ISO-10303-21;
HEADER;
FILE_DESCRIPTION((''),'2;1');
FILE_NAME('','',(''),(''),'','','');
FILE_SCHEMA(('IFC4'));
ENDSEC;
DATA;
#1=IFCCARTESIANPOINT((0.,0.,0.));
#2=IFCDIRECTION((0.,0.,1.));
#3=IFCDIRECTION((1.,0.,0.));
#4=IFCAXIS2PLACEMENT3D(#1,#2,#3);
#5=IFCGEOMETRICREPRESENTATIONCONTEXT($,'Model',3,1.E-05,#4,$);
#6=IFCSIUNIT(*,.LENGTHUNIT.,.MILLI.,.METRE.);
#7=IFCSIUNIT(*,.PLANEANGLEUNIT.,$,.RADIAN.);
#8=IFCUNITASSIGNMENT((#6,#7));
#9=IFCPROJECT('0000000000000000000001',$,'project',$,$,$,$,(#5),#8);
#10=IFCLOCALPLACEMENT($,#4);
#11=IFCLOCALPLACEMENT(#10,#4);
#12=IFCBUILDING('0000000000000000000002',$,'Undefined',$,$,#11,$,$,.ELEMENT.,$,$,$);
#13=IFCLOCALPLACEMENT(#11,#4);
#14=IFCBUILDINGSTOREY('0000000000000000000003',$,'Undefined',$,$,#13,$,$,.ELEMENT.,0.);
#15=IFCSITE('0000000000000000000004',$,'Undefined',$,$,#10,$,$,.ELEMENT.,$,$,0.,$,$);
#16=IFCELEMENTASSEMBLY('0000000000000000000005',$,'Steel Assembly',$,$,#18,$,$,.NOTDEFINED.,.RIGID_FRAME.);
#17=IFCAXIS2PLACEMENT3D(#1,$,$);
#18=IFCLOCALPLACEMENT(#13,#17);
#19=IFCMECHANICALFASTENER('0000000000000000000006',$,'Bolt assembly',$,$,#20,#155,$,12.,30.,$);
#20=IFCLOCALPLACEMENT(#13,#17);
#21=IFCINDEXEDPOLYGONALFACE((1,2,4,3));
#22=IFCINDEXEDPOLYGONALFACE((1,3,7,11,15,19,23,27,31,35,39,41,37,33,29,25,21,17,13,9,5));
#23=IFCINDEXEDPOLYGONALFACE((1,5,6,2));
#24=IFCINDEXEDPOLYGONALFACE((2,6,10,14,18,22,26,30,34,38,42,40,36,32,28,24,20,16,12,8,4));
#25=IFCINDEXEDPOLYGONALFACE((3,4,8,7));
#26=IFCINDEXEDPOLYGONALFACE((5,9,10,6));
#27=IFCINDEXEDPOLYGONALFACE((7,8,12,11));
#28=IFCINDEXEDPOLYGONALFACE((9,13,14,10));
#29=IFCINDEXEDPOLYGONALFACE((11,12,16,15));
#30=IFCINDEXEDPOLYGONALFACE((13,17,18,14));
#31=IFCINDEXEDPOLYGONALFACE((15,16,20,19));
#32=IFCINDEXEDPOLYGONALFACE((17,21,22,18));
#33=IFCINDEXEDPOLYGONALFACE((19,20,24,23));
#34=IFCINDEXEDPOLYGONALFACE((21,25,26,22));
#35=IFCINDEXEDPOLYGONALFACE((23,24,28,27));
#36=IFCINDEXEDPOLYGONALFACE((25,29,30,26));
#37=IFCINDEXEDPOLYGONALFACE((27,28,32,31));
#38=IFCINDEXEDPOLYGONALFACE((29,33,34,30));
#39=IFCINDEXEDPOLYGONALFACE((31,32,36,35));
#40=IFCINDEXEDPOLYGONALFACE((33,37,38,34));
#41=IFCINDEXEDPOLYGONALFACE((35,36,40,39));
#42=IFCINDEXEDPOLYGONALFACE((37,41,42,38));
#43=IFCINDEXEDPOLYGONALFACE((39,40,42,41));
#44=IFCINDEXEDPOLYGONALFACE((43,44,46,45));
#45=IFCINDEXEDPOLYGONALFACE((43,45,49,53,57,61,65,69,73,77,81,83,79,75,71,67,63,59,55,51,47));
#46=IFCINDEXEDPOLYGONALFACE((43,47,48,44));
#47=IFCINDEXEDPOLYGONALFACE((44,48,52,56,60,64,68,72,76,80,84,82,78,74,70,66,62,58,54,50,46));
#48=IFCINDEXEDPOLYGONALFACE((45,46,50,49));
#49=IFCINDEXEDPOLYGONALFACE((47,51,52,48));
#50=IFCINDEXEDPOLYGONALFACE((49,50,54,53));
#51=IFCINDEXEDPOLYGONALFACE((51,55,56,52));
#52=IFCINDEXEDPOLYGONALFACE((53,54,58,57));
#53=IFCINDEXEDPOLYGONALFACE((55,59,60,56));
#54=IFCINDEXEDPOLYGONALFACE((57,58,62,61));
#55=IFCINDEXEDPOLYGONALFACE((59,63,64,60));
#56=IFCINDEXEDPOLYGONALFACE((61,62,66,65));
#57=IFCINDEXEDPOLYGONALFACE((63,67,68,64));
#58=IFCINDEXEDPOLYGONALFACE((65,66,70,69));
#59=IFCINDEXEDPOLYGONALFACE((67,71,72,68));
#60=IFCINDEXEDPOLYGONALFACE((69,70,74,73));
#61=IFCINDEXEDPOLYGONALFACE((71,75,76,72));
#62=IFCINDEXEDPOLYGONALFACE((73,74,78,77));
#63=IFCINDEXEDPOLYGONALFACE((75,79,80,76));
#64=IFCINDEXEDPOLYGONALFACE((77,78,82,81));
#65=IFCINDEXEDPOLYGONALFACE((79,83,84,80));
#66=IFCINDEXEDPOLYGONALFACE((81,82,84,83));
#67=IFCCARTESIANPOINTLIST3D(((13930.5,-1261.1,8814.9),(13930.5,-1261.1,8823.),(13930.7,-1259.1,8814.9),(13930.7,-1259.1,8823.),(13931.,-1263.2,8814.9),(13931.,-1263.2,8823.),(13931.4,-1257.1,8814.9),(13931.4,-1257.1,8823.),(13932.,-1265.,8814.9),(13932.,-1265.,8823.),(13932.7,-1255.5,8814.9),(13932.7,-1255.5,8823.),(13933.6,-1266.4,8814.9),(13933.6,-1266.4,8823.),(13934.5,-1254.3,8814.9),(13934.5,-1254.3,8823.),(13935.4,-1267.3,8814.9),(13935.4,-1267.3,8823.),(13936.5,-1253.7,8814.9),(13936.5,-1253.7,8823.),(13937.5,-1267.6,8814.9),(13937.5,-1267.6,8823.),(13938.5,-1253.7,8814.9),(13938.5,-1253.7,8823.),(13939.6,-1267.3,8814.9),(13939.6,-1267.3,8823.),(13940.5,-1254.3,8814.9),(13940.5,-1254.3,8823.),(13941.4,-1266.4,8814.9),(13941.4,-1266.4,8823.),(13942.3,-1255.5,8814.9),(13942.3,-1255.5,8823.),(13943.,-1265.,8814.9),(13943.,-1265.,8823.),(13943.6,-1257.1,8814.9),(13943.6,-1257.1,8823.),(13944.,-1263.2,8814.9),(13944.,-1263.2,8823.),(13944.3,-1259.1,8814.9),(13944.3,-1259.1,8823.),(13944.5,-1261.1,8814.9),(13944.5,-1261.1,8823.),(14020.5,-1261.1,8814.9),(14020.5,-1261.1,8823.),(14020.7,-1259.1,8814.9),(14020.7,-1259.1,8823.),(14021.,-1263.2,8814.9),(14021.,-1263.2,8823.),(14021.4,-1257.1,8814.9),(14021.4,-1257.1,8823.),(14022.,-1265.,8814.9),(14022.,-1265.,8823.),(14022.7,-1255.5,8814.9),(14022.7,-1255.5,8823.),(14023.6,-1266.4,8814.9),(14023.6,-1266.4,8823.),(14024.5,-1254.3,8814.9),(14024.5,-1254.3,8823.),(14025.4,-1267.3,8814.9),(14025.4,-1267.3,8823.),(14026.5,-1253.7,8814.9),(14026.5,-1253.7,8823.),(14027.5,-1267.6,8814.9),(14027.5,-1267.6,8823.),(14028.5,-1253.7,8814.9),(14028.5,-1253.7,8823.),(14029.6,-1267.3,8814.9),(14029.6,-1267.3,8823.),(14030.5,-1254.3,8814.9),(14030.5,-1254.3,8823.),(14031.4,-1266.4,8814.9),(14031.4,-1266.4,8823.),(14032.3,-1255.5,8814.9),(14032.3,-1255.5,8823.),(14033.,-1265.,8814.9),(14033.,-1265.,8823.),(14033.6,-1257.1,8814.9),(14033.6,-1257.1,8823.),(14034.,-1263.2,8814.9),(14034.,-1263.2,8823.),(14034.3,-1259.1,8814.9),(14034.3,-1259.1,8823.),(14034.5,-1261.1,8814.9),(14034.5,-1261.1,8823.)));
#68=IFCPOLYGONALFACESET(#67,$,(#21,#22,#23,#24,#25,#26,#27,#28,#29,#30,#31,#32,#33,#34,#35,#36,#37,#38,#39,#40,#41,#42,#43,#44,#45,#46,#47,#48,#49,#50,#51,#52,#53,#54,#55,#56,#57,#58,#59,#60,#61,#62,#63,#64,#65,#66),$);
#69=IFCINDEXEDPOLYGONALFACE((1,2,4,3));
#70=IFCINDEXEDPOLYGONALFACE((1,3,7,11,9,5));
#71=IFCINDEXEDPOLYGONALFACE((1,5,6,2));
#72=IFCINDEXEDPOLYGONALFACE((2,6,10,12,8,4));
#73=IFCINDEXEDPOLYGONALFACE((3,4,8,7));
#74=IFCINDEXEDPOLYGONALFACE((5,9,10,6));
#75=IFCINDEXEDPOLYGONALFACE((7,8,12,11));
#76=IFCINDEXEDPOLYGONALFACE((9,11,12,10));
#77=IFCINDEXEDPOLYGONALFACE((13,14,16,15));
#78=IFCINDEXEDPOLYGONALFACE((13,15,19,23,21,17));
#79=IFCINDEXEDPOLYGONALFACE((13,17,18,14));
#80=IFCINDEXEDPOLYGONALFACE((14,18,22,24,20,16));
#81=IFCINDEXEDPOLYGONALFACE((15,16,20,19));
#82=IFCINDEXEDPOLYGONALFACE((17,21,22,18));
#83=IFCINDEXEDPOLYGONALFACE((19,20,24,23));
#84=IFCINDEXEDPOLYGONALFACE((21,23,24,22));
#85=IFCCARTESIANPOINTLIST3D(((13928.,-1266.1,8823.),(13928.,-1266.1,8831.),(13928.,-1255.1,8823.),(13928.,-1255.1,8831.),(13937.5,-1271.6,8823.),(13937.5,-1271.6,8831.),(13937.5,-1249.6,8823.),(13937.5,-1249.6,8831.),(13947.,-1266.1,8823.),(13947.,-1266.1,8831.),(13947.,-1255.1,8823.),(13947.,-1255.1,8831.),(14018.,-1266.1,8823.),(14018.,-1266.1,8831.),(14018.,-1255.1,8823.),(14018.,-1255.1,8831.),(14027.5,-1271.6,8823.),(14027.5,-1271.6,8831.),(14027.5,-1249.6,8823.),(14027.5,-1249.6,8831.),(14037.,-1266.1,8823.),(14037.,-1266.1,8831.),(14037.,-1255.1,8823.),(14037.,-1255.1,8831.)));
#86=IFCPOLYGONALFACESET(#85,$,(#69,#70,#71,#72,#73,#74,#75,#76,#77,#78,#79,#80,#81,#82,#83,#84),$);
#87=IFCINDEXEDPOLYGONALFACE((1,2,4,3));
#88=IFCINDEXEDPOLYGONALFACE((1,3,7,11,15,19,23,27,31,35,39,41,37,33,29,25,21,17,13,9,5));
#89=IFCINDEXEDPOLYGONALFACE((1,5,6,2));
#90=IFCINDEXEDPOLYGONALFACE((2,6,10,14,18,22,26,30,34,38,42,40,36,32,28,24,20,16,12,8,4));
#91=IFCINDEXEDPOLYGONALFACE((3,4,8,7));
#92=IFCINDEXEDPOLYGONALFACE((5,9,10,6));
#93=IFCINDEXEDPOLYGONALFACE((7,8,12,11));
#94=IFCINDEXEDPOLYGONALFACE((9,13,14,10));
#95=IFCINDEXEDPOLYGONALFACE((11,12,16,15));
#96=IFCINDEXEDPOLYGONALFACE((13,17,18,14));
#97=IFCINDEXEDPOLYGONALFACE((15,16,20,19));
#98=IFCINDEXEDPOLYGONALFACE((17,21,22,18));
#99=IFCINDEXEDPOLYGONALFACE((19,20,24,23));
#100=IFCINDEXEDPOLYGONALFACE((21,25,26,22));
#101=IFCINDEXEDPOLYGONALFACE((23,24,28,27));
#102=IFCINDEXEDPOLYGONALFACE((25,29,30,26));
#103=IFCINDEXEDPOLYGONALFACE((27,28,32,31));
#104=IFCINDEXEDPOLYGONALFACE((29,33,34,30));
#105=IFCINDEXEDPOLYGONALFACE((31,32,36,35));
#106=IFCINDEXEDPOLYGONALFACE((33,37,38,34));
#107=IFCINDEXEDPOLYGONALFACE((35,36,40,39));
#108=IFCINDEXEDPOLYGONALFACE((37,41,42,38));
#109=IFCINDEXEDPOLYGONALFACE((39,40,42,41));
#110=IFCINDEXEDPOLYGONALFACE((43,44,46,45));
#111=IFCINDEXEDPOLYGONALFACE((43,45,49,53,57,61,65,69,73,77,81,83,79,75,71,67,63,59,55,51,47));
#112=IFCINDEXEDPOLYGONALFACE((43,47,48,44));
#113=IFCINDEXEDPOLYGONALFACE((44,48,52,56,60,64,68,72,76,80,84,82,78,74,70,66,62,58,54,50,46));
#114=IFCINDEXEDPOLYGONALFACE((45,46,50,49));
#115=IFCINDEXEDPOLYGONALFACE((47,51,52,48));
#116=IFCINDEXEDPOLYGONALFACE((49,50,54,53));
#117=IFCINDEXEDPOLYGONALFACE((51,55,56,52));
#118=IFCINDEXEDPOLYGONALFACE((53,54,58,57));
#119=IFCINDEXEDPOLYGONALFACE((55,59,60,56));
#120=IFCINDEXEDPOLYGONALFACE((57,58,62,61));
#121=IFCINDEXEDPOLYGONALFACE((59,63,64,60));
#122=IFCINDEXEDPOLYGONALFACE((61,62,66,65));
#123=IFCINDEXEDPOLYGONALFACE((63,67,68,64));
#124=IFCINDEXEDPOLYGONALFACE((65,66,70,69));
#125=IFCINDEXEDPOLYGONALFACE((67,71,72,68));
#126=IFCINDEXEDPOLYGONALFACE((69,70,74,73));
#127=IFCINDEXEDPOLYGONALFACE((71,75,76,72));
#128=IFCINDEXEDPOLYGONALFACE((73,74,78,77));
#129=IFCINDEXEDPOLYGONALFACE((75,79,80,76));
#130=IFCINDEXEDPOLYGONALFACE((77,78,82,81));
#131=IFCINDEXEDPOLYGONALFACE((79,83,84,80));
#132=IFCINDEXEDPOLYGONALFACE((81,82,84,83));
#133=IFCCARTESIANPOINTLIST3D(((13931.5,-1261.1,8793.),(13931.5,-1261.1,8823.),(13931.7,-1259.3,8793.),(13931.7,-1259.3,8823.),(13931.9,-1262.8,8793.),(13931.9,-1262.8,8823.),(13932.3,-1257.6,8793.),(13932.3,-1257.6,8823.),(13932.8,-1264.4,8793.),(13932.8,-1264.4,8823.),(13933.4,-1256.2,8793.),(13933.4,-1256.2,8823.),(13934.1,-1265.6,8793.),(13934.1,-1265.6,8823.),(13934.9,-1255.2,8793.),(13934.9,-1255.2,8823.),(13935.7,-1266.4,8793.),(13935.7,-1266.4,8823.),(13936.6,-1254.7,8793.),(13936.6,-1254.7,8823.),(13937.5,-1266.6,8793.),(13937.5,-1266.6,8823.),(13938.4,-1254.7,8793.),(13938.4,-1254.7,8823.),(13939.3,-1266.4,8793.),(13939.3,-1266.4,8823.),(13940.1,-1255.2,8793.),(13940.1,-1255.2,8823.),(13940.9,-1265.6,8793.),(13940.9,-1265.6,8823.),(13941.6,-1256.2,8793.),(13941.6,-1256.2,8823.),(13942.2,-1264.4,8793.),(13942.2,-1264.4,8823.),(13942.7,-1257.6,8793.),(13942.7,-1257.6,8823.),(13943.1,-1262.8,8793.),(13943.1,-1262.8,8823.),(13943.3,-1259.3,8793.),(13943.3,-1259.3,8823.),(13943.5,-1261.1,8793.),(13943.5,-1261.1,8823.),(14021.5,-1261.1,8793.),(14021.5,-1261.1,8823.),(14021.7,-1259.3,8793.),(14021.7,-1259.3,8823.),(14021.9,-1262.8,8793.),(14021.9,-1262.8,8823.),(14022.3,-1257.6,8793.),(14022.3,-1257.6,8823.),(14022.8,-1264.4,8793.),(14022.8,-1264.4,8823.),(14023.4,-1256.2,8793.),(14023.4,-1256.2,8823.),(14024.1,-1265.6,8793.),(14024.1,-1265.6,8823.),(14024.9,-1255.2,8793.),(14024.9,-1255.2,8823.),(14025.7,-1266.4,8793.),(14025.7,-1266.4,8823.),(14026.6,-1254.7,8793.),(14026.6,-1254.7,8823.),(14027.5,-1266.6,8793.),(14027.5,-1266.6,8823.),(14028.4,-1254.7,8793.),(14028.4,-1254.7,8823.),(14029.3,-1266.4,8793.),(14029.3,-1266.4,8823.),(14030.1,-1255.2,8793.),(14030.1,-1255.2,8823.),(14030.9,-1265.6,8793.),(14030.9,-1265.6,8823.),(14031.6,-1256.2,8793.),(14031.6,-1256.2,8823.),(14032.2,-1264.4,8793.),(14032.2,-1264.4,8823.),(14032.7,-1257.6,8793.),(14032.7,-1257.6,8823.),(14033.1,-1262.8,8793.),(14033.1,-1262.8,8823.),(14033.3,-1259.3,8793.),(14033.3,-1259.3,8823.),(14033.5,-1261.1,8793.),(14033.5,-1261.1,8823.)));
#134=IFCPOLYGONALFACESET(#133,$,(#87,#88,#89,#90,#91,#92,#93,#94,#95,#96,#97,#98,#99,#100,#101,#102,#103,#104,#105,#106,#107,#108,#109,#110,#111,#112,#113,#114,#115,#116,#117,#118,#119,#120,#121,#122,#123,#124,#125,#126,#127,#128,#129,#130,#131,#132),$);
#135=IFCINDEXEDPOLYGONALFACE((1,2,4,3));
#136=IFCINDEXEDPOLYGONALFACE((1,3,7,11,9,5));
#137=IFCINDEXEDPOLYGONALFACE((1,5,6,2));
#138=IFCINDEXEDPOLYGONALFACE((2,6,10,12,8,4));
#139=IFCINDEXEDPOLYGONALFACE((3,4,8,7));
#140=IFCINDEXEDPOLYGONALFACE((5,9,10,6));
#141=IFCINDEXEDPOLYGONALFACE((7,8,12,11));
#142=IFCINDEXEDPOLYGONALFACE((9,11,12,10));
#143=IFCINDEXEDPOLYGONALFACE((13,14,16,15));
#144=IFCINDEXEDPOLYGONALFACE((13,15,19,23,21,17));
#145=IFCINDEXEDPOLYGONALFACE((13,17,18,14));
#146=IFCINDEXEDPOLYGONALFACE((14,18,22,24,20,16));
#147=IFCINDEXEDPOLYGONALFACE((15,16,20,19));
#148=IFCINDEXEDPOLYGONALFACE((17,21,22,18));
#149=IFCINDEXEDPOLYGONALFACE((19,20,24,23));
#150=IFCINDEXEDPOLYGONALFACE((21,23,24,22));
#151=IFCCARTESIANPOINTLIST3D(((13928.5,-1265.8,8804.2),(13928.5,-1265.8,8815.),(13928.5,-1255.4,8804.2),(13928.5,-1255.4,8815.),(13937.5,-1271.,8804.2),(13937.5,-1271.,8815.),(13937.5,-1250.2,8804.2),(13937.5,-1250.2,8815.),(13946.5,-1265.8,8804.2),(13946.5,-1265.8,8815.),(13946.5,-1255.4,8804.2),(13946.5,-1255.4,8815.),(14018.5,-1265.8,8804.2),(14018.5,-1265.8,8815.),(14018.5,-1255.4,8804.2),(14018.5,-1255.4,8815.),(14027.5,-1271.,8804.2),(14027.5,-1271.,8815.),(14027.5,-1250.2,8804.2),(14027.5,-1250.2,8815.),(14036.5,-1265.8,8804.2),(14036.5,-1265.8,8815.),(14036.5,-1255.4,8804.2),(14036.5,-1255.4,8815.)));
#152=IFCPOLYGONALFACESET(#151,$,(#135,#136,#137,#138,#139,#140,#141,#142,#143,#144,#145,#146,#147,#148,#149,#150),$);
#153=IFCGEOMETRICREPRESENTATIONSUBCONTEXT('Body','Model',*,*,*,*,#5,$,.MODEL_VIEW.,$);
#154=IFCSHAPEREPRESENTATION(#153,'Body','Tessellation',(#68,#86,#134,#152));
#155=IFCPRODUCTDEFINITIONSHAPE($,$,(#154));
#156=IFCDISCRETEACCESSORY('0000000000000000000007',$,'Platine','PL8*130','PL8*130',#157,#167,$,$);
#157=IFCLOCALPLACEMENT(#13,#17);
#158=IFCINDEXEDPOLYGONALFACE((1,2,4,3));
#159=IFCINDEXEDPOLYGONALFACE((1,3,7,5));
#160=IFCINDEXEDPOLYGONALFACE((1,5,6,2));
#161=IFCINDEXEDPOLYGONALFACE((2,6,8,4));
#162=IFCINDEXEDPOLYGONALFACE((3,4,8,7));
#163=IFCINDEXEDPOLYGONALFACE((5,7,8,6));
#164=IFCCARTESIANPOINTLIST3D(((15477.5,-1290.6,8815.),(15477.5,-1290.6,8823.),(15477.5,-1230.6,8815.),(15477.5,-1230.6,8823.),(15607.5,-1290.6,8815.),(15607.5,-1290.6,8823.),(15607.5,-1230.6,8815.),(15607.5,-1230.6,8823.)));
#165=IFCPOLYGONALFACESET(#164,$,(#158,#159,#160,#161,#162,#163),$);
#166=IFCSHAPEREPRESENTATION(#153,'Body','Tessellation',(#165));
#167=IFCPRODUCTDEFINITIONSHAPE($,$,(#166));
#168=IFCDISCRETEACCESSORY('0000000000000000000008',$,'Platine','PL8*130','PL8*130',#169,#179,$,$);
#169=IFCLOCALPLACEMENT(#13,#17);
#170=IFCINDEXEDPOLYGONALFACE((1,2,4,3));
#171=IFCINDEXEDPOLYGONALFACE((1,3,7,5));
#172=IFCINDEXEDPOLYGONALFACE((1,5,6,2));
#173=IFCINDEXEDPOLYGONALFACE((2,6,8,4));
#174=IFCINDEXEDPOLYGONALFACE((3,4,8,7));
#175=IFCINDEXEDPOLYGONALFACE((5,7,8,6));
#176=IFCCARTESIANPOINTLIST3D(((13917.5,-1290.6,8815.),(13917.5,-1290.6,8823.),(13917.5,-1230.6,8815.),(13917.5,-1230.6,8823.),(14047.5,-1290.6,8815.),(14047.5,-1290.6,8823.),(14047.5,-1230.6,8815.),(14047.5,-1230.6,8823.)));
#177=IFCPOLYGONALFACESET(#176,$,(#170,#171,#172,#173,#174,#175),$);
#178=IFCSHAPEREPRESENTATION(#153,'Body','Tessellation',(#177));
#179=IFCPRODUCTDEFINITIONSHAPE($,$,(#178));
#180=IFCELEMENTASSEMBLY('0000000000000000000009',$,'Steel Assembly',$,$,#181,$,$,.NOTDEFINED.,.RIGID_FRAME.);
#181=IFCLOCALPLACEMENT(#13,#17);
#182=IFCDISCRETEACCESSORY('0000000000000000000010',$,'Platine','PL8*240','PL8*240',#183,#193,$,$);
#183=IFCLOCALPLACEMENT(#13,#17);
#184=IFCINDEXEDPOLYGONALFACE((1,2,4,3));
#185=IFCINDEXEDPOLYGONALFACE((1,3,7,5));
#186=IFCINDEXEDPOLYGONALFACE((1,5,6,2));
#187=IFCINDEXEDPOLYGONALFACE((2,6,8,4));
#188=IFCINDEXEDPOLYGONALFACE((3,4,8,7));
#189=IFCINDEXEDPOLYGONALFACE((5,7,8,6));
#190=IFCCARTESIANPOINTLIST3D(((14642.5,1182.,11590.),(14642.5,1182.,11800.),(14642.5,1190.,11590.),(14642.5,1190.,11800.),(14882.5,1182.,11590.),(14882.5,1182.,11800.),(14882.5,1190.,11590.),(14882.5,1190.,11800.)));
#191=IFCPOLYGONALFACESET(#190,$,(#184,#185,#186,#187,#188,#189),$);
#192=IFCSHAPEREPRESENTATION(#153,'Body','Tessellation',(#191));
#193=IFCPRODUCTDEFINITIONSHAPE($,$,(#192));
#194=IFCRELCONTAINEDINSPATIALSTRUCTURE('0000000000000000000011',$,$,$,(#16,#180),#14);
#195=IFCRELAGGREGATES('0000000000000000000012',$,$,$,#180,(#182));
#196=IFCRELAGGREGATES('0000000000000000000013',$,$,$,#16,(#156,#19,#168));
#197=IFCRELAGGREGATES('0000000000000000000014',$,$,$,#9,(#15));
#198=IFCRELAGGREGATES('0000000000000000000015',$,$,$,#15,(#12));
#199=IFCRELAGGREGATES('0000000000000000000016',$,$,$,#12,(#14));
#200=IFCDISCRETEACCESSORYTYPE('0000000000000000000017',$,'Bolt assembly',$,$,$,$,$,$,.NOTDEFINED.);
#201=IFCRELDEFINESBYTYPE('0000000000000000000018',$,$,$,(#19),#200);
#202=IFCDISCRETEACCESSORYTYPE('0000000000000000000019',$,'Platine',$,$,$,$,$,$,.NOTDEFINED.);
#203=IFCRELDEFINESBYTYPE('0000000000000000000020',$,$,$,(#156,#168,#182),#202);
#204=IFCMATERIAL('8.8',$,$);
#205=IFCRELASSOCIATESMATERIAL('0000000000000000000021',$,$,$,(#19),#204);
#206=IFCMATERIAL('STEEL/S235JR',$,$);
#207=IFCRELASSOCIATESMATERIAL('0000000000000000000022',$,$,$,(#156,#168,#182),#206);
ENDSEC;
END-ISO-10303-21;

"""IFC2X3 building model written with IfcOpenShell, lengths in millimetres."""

from ifc_helpers import new_model, si_unit, frame, origin_with_axes, origin_2d_with_axis, place, context, subcontext, project, spatial, polyline, circle, outline, extrude, source, transform, mapped, material, type_object, element, aggregate, save


model = new_model("IFC2X3")

# Units and contexts
model_context = context("Model", 3, precision=1e-05, world=origin_with_axes())
body_context = subcontext(model_context, "Body", "Model", "MODEL_VIEW")
ifc_project = project(units=[si_unit("LENGTHUNIT", "METRE", prefix="MILLI"), si_unit("PLANEANGLEUNIT", "RADIAN")], contexts=[model_context])

# Site, building, storey
site_placement = place(None, origin_with_axes())
site = spatial("IfcSite", under=ifc_project, at=site_placement, Name="Undefined", CompositionType="ELEMENT", RefElevation=0.0)
building_placement = place(site_placement, origin_with_axes())
building = spatial("IfcBuilding", under=site, at=building_placement, Name="Undefined", CompositionType="ELEMENT")
storey_placement = place(building_placement, origin_with_axes())
storey = spatial("IfcBuildingStorey", under=building, at=storey_placement, Name="Undefined", CompositionType="ELEMENT", Elevation=0.0)

# Shared definitions
ifc_material_1 = material(Name="STEEL/S235JR")

# Element assembly, mechanical fastener, discrete accessories
assembly_1_placement = place(storey_placement, origin_with_axes())
assembly_1 = element("IfcElementAssembly", 1, at=assembly_1_placement, inside=storey, Name="Steel Assembly", AssemblyPlace="NOTDEFINED", PredefinedType="RIGID_FRAME")
ifc_material_2 = material(Name="8.8")
discrete_accessory_type_1 = type_object("IfcDiscreteAccessoryType", Name="Bolt assembly")
shared_shape_1 = source(origin_with_axes(), body_context, "Body", "SweptSolid", [
    extrude(circle(Radius=7.0, at=origin_2d_with_axis()), frame((0.0, 0.0, 0.0), z_axis=(0.0, 1.0, 0.0), x_axis=(1.0, 0.0, 0.0)), (0.0, 0.0, 1.0), 8.1),
    extrude(outline(polyline([(11.0, 0.0), (5.5, 9.5), (-5.5, 9.5), (-11.0, 0.0), (-5.5, -9.5), (5.5, -9.5), (11.0, 0.0)])), frame((0.0, -8.0, 0.0), z_axis=(0.0, 1.0, 0.0), x_axis=(1.0, 0.0, 0.0)), (0.0, 0.0, 1.0), 8.0),
    extrude(circle(Radius=6.0, at=origin_2d_with_axis()), frame((0.0, 0.0, 0.0), z_axis=(0.0, 1.0, 0.0), x_axis=(1.0, 0.0, 0.0)), (0.0, 0.0, 1.0), 30.0),
    extrude(outline(polyline([(10.4, 0.0), (5.2, 9.0), (-5.2, 9.0), (-10.4, 0.0), (-5.2, -9.0), (5.2, -9.0), (10.4, 0.0)])), frame((0.0, 8.0, 0.0), z_axis=(0.0, 1.0, 0.0), x_axis=(1.0, 0.0, 0.0)), (0.0, 0.0, 1.0), 10.8),
])
mechanical_fastener_1_placement = place(assembly_1_placement, frame((13982.5, -1240.6, 8823.0), z_axis=(1.0, 0.0, 0.0), x_axis=(0.0, -1.0, 0.0)))
mechanical_fastener_1 = element("IfcMechanicalFastener", 2, at=mechanical_fastener_1_placement, type_object=discrete_accessory_type_1, material=ifc_material_2, Name="Bolt assembly", NominalDiameter=12.0, NominalLength=30.0, context=body_context, shape_type="MappedRepresentation", body=[
    mapped(shared_shape_1, transform((20.0, 0.0, -45.0))),
    mapped(shared_shape_1, transform((20.0, 0.0, 45.0))),
])
discrete_accessory_type_2 = type_object("IfcDiscreteAccessoryType", Name="Platine")
discrete_accessory_1_placement = place(assembly_1_placement, frame((15542.5, -1290.6, 8819.0), z_axis=(0.0, 0.0, 1.0), x_axis=(0.0, 1.0, 0.0)))
discrete_accessory_1 = element("IfcDiscreteAccessory", 3, at=discrete_accessory_1_placement, type_object=discrete_accessory_type_2, material=ifc_material_1, Name="Platine", Description="PL8*130", ObjectType="PL8*130", context=body_context, shape_type="SweptSolid", body=[
    extrude(outline(polyline([(60.0, 65.0), (60.0, -65.0), (0.0, -65.0), (0.0, 65.0), (60.0, 65.0)])), frame((0.0, 0.0, -4.0), z_axis=(0.0, 0.0, 1.0), x_axis=(1.0, 0.0, 0.0)), (0.0, 0.0, 1.0), 8.0),
])
discrete_accessory_2_placement = place(assembly_1_placement, frame((13982.5, -1290.6, 8819.0), z_axis=(0.0, 0.0, 1.0), x_axis=(0.0, 1.0, 0.0)))
discrete_accessory_2 = element("IfcDiscreteAccessory", 4, at=discrete_accessory_2_placement, type_object=discrete_accessory_type_2, material=ifc_material_1, Name="Platine", Description="PL8*130", ObjectType="PL8*130", context=body_context, shape_type="SweptSolid", body=[
    extrude(outline(polyline([(60.0, 65.0), (60.0, -65.0), (0.0, -65.0), (0.0, 65.0), (60.0, 65.0)])), frame((0.0, 0.0, -4.0), z_axis=(0.0, 0.0, 1.0), x_axis=(1.0, 0.0, 0.0)), (0.0, 0.0, 1.0), 8.0),
])

# Element assembly, discrete accessory
assembly_2_placement = place(storey_placement, origin_with_axes())
assembly_2 = element("IfcElementAssembly", 5, at=assembly_2_placement, inside=storey, Name="Steel Assembly", AssemblyPlace="NOTDEFINED", PredefinedType="RIGID_FRAME")
discrete_accessory_3_placement = place(assembly_2_placement, frame((14762.5, 1186.0, 11590.0), z_axis=(0.0, -1.0, 0.0), x_axis=(0.0, 0.0, 1.0)))
discrete_accessory_3 = element("IfcDiscreteAccessory", 6, at=discrete_accessory_3_placement, type_object=discrete_accessory_type_2, material=ifc_material_1, Name="Platine", Description="PL8*240", ObjectType="PL8*240", context=body_context, shape_type="SweptSolid", body=[
    extrude(outline(polyline([(210.0, 120.0), (210.0, -120.0), (0.0, -120.0), (0.0, 120.0), (210.0, 120.0)])), frame((0.0, 0.0, -4.0), z_axis=(0.0, 0.0, 1.0), x_axis=(1.0, 0.0, 0.0)), (0.0, 0.0, 1.0), 8.0),
])
aggregate(assembly_2, [discrete_accessory_3])

aggregate(assembly_1, [discrete_accessory_1, mechanical_fastener_1, discrete_accessory_2])

save(model, "model.ifc")
